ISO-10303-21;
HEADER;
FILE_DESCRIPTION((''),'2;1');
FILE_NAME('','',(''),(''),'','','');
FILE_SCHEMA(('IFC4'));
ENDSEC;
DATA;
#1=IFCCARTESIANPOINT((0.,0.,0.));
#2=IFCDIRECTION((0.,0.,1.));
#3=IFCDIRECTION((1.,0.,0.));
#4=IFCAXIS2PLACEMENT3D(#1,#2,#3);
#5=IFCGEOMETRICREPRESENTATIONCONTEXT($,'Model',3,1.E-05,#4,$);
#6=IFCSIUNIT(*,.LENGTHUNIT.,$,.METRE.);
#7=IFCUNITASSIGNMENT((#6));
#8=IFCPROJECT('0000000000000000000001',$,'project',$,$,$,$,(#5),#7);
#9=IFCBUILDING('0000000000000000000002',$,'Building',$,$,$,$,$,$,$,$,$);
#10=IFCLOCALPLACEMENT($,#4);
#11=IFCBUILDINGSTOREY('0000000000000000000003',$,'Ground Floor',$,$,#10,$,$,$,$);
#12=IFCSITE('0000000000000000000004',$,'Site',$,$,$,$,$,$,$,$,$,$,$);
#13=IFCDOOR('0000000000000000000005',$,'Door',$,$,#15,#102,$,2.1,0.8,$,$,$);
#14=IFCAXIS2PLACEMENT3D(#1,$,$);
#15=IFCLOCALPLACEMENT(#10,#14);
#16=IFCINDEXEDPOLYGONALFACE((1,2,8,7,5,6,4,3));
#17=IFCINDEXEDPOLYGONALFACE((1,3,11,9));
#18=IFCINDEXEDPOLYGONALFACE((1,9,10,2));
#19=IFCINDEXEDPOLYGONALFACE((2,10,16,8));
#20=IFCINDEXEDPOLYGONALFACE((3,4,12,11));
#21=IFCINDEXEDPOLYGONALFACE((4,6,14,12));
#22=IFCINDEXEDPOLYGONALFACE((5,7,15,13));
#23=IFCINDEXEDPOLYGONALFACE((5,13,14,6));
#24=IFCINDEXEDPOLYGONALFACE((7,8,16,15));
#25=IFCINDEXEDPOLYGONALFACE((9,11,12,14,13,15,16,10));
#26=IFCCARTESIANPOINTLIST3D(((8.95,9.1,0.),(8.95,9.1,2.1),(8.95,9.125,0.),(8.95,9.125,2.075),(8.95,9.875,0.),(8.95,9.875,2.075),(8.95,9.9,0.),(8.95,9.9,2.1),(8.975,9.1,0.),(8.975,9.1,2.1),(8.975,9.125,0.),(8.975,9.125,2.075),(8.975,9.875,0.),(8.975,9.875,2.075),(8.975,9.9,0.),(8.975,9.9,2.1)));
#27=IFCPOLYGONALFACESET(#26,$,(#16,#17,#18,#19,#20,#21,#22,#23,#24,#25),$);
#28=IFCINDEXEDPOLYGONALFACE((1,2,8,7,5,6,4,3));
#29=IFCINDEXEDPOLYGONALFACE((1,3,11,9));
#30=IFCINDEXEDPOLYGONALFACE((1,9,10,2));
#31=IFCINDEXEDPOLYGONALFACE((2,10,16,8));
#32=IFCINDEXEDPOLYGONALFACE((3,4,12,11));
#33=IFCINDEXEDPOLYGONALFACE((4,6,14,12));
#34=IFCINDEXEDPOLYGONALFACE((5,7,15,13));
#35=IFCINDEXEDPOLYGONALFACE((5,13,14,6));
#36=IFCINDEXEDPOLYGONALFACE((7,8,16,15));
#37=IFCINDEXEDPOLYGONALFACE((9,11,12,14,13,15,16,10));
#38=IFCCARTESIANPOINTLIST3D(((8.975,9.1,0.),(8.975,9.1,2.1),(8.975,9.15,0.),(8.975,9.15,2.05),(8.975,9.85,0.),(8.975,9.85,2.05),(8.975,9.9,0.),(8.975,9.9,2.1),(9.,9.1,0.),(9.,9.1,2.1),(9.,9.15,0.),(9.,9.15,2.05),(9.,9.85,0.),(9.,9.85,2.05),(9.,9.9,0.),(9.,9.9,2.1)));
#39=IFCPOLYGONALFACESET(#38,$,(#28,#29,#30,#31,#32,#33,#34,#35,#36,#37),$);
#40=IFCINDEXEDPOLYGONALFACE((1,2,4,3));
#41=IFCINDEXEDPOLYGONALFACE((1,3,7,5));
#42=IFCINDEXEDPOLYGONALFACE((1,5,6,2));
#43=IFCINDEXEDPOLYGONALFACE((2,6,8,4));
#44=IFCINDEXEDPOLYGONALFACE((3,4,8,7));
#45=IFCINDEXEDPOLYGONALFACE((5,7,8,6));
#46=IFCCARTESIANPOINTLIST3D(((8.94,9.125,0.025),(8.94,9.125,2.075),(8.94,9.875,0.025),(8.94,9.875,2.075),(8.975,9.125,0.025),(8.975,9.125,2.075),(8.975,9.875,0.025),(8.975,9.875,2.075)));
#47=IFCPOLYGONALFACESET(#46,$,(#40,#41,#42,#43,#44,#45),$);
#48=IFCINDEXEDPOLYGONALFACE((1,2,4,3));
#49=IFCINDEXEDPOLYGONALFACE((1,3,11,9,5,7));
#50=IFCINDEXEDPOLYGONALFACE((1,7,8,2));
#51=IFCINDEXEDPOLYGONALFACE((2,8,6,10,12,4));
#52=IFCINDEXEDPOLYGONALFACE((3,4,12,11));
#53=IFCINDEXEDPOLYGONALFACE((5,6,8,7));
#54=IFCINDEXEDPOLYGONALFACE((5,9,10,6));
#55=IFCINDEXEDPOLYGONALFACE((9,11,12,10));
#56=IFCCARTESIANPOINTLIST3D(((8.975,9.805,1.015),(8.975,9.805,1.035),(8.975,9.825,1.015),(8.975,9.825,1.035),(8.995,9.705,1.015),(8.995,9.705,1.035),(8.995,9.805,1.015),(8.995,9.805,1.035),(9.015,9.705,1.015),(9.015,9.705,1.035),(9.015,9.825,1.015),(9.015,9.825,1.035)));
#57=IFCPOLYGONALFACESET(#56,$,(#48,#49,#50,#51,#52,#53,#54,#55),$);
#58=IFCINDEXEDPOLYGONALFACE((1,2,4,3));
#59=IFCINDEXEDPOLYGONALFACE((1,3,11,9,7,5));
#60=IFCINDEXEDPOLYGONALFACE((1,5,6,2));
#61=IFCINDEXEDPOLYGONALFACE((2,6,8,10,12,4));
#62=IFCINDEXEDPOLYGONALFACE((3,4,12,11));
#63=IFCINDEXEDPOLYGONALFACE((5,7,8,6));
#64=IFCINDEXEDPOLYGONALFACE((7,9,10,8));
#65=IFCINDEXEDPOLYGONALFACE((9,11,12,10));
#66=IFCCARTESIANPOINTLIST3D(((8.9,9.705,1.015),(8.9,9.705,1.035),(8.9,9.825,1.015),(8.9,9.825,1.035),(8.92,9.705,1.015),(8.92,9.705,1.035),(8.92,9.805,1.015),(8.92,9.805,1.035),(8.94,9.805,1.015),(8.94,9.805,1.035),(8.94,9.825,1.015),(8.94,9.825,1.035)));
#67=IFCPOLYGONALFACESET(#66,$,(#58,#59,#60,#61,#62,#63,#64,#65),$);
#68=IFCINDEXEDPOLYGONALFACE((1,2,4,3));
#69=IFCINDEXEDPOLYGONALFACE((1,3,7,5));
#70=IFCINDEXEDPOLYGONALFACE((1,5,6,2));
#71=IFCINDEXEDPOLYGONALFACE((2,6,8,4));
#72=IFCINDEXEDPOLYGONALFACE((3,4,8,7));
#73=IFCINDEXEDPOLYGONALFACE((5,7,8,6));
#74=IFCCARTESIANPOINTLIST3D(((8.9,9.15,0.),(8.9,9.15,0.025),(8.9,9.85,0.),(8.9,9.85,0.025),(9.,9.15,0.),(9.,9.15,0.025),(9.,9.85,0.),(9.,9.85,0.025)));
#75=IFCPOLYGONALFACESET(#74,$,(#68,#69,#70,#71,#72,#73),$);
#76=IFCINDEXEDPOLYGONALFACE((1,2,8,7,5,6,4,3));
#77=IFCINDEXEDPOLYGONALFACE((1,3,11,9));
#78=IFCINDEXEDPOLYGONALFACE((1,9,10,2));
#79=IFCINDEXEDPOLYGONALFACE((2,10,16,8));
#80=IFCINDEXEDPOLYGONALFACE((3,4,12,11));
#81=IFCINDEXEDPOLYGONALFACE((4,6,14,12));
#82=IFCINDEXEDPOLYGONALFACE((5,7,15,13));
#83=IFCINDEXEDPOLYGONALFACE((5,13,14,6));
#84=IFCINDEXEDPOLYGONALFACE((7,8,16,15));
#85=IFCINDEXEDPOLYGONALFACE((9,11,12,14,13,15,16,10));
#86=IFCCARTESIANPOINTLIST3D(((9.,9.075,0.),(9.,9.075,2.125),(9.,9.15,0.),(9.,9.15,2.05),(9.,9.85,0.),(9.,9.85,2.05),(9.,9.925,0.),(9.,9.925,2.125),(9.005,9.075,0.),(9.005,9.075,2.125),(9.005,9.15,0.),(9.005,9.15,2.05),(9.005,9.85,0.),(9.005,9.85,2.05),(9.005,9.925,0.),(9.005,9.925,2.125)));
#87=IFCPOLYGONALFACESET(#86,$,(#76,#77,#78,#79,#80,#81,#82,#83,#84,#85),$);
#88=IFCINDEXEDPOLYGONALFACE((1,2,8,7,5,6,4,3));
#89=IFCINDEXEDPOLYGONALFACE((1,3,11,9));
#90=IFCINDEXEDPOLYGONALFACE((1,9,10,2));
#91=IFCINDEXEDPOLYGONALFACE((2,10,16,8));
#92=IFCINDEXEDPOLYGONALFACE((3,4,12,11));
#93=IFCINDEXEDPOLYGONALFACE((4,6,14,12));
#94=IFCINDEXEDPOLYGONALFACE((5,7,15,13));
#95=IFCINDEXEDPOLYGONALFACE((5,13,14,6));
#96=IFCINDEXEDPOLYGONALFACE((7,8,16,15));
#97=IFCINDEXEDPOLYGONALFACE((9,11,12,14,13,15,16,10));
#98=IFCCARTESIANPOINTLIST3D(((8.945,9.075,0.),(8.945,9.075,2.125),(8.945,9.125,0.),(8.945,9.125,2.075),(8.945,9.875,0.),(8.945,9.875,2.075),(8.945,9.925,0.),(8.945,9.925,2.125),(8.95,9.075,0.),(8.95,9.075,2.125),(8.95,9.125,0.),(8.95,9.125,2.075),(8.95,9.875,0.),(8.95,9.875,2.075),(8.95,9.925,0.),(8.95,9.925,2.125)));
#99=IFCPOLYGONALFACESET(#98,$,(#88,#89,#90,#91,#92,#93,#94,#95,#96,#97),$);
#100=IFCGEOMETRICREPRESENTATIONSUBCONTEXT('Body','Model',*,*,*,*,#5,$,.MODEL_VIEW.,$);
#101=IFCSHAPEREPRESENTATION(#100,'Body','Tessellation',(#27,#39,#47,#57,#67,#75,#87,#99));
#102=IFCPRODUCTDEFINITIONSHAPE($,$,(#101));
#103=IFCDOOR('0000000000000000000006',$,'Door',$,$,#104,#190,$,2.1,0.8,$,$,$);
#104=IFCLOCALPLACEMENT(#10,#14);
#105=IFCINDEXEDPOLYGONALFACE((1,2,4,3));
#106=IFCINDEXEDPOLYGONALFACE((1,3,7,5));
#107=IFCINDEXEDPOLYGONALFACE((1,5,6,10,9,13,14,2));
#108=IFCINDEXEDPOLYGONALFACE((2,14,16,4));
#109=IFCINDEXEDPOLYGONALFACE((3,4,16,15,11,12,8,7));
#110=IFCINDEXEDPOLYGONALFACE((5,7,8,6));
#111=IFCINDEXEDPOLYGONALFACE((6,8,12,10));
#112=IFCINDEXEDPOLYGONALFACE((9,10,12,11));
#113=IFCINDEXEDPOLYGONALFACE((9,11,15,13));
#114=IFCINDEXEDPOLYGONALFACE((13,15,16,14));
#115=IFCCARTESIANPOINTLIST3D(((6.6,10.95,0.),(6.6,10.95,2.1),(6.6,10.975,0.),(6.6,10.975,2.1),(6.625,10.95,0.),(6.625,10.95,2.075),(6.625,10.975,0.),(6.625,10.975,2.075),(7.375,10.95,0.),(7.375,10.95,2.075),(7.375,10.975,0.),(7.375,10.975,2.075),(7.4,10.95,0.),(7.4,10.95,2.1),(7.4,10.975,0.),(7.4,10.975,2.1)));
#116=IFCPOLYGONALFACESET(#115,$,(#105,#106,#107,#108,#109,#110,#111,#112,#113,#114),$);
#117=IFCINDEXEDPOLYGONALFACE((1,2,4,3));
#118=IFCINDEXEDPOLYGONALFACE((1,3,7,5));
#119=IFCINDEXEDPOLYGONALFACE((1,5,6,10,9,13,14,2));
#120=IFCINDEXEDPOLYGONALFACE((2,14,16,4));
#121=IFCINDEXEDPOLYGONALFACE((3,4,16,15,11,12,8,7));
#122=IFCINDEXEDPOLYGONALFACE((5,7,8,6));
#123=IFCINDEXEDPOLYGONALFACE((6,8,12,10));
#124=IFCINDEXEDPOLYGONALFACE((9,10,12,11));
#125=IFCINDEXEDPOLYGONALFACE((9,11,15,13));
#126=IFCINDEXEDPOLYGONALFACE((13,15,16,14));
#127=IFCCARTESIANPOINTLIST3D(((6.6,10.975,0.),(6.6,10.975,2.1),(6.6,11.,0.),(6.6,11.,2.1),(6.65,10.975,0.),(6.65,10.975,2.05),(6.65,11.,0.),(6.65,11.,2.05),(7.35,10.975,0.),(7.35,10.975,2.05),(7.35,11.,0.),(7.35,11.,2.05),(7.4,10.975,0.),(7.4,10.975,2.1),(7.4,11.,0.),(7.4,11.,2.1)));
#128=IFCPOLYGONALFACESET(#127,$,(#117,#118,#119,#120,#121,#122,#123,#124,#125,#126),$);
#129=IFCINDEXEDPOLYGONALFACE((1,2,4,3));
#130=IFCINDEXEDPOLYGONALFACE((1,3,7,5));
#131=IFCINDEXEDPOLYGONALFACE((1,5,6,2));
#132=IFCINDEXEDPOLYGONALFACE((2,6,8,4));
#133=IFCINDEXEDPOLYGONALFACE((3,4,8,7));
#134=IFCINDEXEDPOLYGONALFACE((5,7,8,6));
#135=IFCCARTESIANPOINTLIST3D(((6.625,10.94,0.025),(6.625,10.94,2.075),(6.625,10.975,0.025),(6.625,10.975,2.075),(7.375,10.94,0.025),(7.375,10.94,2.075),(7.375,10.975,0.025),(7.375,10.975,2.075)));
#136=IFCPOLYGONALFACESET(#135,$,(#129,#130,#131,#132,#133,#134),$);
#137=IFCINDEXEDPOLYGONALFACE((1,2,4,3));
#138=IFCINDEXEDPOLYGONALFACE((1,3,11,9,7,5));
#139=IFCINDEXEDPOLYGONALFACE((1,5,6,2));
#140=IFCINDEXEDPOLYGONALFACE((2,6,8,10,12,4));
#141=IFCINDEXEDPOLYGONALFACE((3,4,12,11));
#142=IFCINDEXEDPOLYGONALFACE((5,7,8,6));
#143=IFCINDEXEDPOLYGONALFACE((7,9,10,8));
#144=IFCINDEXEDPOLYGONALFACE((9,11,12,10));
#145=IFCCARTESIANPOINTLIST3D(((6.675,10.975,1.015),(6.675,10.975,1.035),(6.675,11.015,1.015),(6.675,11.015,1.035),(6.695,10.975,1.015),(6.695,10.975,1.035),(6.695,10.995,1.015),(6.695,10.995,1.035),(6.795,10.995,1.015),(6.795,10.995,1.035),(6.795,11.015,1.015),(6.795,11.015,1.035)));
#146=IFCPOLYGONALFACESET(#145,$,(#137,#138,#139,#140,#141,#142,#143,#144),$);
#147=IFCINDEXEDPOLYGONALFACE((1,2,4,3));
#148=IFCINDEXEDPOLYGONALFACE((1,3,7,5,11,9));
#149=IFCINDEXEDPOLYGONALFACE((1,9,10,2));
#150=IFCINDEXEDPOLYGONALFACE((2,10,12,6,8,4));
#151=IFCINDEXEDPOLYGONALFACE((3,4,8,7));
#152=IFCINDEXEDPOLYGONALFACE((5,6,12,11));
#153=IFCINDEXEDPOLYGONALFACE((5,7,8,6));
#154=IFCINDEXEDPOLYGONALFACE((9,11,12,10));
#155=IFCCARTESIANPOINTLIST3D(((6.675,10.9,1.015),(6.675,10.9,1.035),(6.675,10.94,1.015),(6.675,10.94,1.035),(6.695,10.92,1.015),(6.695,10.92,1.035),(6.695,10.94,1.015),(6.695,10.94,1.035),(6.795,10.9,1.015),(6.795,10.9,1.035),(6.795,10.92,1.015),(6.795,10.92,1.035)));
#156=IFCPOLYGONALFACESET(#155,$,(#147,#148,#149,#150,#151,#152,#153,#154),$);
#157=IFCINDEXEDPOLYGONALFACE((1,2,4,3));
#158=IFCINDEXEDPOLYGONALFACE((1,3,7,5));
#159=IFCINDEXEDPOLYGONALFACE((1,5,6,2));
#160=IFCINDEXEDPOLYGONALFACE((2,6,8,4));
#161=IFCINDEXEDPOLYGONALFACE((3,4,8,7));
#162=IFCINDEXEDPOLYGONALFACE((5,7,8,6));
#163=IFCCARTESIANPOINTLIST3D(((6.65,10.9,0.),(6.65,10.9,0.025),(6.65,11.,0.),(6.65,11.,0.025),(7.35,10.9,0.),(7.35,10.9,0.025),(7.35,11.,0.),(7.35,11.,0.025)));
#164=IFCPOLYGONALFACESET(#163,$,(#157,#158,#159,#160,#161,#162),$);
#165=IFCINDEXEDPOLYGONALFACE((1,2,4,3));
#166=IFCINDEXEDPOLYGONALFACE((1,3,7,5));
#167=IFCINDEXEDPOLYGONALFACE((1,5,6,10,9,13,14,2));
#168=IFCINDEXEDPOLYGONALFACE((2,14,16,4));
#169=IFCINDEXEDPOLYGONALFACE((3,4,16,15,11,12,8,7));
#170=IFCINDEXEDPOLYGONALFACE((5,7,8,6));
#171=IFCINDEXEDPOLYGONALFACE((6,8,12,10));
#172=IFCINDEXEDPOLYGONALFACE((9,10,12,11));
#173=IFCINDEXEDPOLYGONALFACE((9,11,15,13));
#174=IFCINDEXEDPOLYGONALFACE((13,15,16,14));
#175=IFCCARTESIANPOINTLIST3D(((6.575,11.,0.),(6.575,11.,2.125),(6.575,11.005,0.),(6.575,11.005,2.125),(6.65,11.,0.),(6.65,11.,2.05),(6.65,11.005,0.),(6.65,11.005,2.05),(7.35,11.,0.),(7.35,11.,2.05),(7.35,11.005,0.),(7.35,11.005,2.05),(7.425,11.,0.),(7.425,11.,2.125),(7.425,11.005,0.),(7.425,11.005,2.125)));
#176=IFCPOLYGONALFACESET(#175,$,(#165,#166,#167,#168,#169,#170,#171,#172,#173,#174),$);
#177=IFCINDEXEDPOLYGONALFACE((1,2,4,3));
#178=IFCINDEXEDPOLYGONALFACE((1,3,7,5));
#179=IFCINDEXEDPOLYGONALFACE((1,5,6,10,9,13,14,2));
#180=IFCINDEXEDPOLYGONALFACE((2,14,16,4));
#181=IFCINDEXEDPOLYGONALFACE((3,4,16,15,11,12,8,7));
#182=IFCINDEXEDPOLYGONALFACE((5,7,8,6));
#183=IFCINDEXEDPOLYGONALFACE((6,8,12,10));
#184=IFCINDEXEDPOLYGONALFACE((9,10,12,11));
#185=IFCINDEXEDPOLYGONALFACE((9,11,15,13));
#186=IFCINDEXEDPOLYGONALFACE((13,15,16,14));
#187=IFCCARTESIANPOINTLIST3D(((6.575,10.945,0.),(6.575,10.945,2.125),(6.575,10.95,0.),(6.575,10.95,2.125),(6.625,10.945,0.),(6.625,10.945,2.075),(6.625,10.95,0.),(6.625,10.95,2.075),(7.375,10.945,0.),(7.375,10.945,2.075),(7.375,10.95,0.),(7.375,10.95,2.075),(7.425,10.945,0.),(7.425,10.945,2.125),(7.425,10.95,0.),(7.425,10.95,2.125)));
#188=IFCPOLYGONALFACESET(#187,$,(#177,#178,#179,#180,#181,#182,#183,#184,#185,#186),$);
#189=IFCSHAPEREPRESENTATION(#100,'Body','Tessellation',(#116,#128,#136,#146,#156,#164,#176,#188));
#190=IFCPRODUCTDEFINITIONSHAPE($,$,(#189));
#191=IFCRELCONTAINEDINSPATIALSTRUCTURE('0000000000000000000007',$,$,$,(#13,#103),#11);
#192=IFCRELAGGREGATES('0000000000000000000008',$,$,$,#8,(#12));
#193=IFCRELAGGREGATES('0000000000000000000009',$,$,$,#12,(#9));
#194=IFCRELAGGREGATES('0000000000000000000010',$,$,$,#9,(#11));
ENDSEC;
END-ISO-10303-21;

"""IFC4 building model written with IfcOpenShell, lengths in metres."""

from ifc_helpers import new_model, si_unit, frame, origin_with_axes, place, context, subcontext, project, spatial, line, indexed_curve, outline, extrude, element, save


model = new_model("IFC4")

# Units and contexts
model_context = context("Model", 3, precision=1e-05, world=origin_with_axes())
body_context = subcontext(model_context, "Body", "Model", "MODEL_VIEW")
ifc_project = project(units=[si_unit("LENGTHUNIT", "METRE")], contexts=[model_context])

# Site, building, storey
site = spatial("IfcSite", under=ifc_project, Name="Site")
building = spatial("IfcBuilding", under=site, Name="Building")
storey_placement = place(None, origin_with_axes())
storey = spatial("IfcBuildingStorey", under=building, at=storey_placement, Name="Ground Floor")

# Doors
door_1_placement = place(storey_placement, frame((9.0, 9.1, 0.0), z_axis=(0.0, 0.0, 1.0), x_axis=(0.0, 1.0, 0.0)))
element("IfcDoor", 1, at=door_1_placement, inside=storey, Name="Door", OverallHeight=2.1, OverallWidth=0.8, context=body_context, shape_type="SweptSolid", body=[
    extrude(outline(indexed_curve([(0.0, 0.0), (0.0, 2.1), (0.8, 2.1), (0.8, 0.0), (0.775, 0.0), (0.775, 2.075), (0.025, 2.075), (0.025, 0.0)], segments=[line(1, 2, 3, 4, 5, 6, 7, 8, 1)])), frame((0.0, 0.025, 0.0), z_axis=(0.0, -1.0, 0.0), x_axis=(1.0, 0.0, 0.0)), (0.0, 0.0, -1.0), 0.025),
    extrude(outline(indexed_curve([(0.0, 0.0), (0.0, 2.1), (0.8, 2.1), (0.8, 0.0), (0.75, 0.0), (0.75, 2.05), (0.05, 2.05), (0.05, 0.0)], segments=[line(1, 2, 3, 4, 5, 6, 7, 8, 1)])), frame((0.0, 0.0, 0.0), z_axis=(0.0, -1.0, 0.0), x_axis=(1.0, 0.0, 0.0)), (0.0, 0.0, -1.0), 0.025),
    extrude(outline(indexed_curve([(0.0, 0.0), (0.75, 0.0), (0.75, 0.035), (0.0, 0.035)], segments=[line(1, 2, 3, 4, 1)])), frame((0.025, 0.025, 0.025), z_axis=(0.0, 0.0, 1.0), x_axis=(1.0, 0.0, 0.0)), (0.0, 0.0, 1.0), 2.05),
    extrude(outline(indexed_curve([(0.0, 0.0), (0.0, -0.04), (-0.12, -0.04), (-0.12, -0.02), (-0.02, -0.02), (-0.02, 0.0)], segments=[line(1, 2, 3, 4, 5, 6, 1)])), frame((0.725, 0.025, 1.015), z_axis=(0.0, 0.0, 1.0), x_axis=(1.0, 0.0, 0.0)), (0.0, 0.0, 1.0), 0.02),
    extrude(outline(indexed_curve([(0.0, 0.0), (0.0, 0.04), (-0.12, 0.04), (-0.12, 0.02), (-0.02, 0.02), (-0.02, 0.0)], segments=[line(1, 2, 3, 4, 5, 6, 1)])), frame((0.725, 0.06, 1.015), z_axis=(0.0, 0.0, 1.0), x_axis=(1.0, 0.0, 0.0)), (0.0, 0.0, 1.0), 0.02),
    extrude(outline(indexed_curve([(0.0, 0.0), (0.7, 0.0), (0.7, 0.1), (0.0, 0.1)], segments=[line(1, 2, 3, 4, 1)])), frame((0.05, 0.0, 0.0), z_axis=(0.0, 0.0, 1.0), x_axis=(1.0, 0.0, 0.0)), (0.0, 0.0, 1.0), 0.025),
    extrude(outline(indexed_curve([(0.0, 0.0), (0.0, 2.125), (0.85, 2.125), (0.85, 0.0), (0.775, 0.0), (0.775, 2.05), (0.075, 2.05), (0.075, 0.0)], segments=[line(1, 2, 3, 4, 5, 6, 7, 8, 1)])), frame((-0.025, -0.005, 0.0), z_axis=(0.0, -1.0, 0.0), x_axis=(1.0, 0.0, 0.0)), (0.0, 0.0, -1.0), 0.005),
    extrude(outline(indexed_curve([(0.0, 0.0), (0.0, 2.125), (0.85, 2.125), (0.85, 0.0), (0.8, 0.0), (0.8, 2.075), (0.05, 2.075), (0.05, 0.0)], segments=[line(1, 2, 3, 4, 5, 6, 7, 8, 1)])), frame((-0.025, 0.05, 0.0), z_axis=(0.0, -1.0, 0.0), x_axis=(1.0, 0.0, 0.0)), (0.0, 0.0, -1.0), 0.005),
])
door_2_placement = place(storey_placement, frame((7.4, 11.0, 0.0), z_axis=(0.0, 0.0, 1.0), x_axis=(-1.0, 0.0, 0.0)))
element("IfcDoor", 2, at=door_2_placement, inside=storey, Name="Door", OverallHeight=2.1, OverallWidth=0.8, context=body_context, shape_type="SweptSolid", body=[
    extrude(outline(indexed_curve([(0.0, 0.0), (0.0, 2.1), (0.8, 2.1), (0.8, 0.0), (0.775, 0.0), (0.775, 2.075), (0.025, 2.075), (0.025, 0.0)], segments=[line(1, 2, 3, 4, 5, 6, 7, 8, 1)])), frame((0.0, 0.025, 0.0), z_axis=(0.0, -1.0, 0.0), x_axis=(1.0, 0.0, 0.0)), (0.0, 0.0, -1.0), 0.025),
    extrude(outline(indexed_curve([(0.0, 0.0), (0.0, 2.1), (0.8, 2.1), (0.8, 0.0), (0.75, 0.0), (0.75, 2.05), (0.05, 2.05), (0.05, 0.0)], segments=[line(1, 2, 3, 4, 5, 6, 7, 8, 1)])), frame((0.0, 0.0, 0.0), z_axis=(0.0, -1.0, 0.0), x_axis=(1.0, 0.0, 0.0)), (0.0, 0.0, -1.0), 0.025),
    extrude(outline(indexed_curve([(0.0, 0.0), (0.75, 0.0), (0.75, 0.035), (0.0, 0.035)], segments=[line(1, 2, 3, 4, 1)])), frame((0.025, 0.025, 0.025), z_axis=(0.0, 0.0, 1.0), x_axis=(1.0, 0.0, 0.0)), (0.0, 0.0, 1.0), 2.05),
    extrude(outline(indexed_curve([(0.0, 0.0), (0.0, -0.04), (-0.12, -0.04), (-0.12, -0.02), (-0.02, -0.02), (-0.02, 0.0)], segments=[line(1, 2, 3, 4, 5, 6, 1)])), frame((0.725, 0.025, 1.015), z_axis=(0.0, 0.0, 1.0), x_axis=(1.0, 0.0, 0.0)), (0.0, 0.0, 1.0), 0.02),
    extrude(outline(indexed_curve([(0.0, 0.0), (0.0, 0.04), (-0.12, 0.04), (-0.12, 0.02), (-0.02, 0.02), (-0.02, 0.0)], segments=[line(1, 2, 3, 4, 5, 6, 1)])), frame((0.725, 0.06, 1.015), z_axis=(0.0, 0.0, 1.0), x_axis=(1.0, 0.0, 0.0)), (0.0, 0.0, 1.0), 0.02),
    extrude(outline(indexed_curve([(0.0, 0.0), (0.7, 0.0), (0.7, 0.1), (0.0, 0.1)], segments=[line(1, 2, 3, 4, 1)])), frame((0.05, 0.0, 0.0), z_axis=(0.0, 0.0, 1.0), x_axis=(1.0, 0.0, 0.0)), (0.0, 0.0, 1.0), 0.025),
    extrude(outline(indexed_curve([(0.0, 0.0), (0.0, 2.125), (0.85, 2.125), (0.85, 0.0), (0.775, 0.0), (0.775, 2.05), (0.075, 2.05), (0.075, 0.0)], segments=[line(1, 2, 3, 4, 5, 6, 7, 8, 1)])), frame((-0.025, -0.005, 0.0), z_axis=(0.0, -1.0, 0.0), x_axis=(1.0, 0.0, 0.0)), (0.0, 0.0, -1.0), 0.005),
    extrude(outline(indexed_curve([(0.0, 0.0), (0.0, 2.125), (0.85, 2.125), (0.85, 0.0), (0.8, 0.0), (0.8, 2.075), (0.05, 2.075), (0.05, 0.0)], segments=[line(1, 2, 3, 4, 5, 6, 7, 8, 1)])), frame((-0.025, 0.05, 0.0), z_axis=(0.0, -1.0, 0.0), x_axis=(1.0, 0.0, 0.0)), (0.0, 0.0, -1.0), 0.005),
])

save(model, "model.ifc")
